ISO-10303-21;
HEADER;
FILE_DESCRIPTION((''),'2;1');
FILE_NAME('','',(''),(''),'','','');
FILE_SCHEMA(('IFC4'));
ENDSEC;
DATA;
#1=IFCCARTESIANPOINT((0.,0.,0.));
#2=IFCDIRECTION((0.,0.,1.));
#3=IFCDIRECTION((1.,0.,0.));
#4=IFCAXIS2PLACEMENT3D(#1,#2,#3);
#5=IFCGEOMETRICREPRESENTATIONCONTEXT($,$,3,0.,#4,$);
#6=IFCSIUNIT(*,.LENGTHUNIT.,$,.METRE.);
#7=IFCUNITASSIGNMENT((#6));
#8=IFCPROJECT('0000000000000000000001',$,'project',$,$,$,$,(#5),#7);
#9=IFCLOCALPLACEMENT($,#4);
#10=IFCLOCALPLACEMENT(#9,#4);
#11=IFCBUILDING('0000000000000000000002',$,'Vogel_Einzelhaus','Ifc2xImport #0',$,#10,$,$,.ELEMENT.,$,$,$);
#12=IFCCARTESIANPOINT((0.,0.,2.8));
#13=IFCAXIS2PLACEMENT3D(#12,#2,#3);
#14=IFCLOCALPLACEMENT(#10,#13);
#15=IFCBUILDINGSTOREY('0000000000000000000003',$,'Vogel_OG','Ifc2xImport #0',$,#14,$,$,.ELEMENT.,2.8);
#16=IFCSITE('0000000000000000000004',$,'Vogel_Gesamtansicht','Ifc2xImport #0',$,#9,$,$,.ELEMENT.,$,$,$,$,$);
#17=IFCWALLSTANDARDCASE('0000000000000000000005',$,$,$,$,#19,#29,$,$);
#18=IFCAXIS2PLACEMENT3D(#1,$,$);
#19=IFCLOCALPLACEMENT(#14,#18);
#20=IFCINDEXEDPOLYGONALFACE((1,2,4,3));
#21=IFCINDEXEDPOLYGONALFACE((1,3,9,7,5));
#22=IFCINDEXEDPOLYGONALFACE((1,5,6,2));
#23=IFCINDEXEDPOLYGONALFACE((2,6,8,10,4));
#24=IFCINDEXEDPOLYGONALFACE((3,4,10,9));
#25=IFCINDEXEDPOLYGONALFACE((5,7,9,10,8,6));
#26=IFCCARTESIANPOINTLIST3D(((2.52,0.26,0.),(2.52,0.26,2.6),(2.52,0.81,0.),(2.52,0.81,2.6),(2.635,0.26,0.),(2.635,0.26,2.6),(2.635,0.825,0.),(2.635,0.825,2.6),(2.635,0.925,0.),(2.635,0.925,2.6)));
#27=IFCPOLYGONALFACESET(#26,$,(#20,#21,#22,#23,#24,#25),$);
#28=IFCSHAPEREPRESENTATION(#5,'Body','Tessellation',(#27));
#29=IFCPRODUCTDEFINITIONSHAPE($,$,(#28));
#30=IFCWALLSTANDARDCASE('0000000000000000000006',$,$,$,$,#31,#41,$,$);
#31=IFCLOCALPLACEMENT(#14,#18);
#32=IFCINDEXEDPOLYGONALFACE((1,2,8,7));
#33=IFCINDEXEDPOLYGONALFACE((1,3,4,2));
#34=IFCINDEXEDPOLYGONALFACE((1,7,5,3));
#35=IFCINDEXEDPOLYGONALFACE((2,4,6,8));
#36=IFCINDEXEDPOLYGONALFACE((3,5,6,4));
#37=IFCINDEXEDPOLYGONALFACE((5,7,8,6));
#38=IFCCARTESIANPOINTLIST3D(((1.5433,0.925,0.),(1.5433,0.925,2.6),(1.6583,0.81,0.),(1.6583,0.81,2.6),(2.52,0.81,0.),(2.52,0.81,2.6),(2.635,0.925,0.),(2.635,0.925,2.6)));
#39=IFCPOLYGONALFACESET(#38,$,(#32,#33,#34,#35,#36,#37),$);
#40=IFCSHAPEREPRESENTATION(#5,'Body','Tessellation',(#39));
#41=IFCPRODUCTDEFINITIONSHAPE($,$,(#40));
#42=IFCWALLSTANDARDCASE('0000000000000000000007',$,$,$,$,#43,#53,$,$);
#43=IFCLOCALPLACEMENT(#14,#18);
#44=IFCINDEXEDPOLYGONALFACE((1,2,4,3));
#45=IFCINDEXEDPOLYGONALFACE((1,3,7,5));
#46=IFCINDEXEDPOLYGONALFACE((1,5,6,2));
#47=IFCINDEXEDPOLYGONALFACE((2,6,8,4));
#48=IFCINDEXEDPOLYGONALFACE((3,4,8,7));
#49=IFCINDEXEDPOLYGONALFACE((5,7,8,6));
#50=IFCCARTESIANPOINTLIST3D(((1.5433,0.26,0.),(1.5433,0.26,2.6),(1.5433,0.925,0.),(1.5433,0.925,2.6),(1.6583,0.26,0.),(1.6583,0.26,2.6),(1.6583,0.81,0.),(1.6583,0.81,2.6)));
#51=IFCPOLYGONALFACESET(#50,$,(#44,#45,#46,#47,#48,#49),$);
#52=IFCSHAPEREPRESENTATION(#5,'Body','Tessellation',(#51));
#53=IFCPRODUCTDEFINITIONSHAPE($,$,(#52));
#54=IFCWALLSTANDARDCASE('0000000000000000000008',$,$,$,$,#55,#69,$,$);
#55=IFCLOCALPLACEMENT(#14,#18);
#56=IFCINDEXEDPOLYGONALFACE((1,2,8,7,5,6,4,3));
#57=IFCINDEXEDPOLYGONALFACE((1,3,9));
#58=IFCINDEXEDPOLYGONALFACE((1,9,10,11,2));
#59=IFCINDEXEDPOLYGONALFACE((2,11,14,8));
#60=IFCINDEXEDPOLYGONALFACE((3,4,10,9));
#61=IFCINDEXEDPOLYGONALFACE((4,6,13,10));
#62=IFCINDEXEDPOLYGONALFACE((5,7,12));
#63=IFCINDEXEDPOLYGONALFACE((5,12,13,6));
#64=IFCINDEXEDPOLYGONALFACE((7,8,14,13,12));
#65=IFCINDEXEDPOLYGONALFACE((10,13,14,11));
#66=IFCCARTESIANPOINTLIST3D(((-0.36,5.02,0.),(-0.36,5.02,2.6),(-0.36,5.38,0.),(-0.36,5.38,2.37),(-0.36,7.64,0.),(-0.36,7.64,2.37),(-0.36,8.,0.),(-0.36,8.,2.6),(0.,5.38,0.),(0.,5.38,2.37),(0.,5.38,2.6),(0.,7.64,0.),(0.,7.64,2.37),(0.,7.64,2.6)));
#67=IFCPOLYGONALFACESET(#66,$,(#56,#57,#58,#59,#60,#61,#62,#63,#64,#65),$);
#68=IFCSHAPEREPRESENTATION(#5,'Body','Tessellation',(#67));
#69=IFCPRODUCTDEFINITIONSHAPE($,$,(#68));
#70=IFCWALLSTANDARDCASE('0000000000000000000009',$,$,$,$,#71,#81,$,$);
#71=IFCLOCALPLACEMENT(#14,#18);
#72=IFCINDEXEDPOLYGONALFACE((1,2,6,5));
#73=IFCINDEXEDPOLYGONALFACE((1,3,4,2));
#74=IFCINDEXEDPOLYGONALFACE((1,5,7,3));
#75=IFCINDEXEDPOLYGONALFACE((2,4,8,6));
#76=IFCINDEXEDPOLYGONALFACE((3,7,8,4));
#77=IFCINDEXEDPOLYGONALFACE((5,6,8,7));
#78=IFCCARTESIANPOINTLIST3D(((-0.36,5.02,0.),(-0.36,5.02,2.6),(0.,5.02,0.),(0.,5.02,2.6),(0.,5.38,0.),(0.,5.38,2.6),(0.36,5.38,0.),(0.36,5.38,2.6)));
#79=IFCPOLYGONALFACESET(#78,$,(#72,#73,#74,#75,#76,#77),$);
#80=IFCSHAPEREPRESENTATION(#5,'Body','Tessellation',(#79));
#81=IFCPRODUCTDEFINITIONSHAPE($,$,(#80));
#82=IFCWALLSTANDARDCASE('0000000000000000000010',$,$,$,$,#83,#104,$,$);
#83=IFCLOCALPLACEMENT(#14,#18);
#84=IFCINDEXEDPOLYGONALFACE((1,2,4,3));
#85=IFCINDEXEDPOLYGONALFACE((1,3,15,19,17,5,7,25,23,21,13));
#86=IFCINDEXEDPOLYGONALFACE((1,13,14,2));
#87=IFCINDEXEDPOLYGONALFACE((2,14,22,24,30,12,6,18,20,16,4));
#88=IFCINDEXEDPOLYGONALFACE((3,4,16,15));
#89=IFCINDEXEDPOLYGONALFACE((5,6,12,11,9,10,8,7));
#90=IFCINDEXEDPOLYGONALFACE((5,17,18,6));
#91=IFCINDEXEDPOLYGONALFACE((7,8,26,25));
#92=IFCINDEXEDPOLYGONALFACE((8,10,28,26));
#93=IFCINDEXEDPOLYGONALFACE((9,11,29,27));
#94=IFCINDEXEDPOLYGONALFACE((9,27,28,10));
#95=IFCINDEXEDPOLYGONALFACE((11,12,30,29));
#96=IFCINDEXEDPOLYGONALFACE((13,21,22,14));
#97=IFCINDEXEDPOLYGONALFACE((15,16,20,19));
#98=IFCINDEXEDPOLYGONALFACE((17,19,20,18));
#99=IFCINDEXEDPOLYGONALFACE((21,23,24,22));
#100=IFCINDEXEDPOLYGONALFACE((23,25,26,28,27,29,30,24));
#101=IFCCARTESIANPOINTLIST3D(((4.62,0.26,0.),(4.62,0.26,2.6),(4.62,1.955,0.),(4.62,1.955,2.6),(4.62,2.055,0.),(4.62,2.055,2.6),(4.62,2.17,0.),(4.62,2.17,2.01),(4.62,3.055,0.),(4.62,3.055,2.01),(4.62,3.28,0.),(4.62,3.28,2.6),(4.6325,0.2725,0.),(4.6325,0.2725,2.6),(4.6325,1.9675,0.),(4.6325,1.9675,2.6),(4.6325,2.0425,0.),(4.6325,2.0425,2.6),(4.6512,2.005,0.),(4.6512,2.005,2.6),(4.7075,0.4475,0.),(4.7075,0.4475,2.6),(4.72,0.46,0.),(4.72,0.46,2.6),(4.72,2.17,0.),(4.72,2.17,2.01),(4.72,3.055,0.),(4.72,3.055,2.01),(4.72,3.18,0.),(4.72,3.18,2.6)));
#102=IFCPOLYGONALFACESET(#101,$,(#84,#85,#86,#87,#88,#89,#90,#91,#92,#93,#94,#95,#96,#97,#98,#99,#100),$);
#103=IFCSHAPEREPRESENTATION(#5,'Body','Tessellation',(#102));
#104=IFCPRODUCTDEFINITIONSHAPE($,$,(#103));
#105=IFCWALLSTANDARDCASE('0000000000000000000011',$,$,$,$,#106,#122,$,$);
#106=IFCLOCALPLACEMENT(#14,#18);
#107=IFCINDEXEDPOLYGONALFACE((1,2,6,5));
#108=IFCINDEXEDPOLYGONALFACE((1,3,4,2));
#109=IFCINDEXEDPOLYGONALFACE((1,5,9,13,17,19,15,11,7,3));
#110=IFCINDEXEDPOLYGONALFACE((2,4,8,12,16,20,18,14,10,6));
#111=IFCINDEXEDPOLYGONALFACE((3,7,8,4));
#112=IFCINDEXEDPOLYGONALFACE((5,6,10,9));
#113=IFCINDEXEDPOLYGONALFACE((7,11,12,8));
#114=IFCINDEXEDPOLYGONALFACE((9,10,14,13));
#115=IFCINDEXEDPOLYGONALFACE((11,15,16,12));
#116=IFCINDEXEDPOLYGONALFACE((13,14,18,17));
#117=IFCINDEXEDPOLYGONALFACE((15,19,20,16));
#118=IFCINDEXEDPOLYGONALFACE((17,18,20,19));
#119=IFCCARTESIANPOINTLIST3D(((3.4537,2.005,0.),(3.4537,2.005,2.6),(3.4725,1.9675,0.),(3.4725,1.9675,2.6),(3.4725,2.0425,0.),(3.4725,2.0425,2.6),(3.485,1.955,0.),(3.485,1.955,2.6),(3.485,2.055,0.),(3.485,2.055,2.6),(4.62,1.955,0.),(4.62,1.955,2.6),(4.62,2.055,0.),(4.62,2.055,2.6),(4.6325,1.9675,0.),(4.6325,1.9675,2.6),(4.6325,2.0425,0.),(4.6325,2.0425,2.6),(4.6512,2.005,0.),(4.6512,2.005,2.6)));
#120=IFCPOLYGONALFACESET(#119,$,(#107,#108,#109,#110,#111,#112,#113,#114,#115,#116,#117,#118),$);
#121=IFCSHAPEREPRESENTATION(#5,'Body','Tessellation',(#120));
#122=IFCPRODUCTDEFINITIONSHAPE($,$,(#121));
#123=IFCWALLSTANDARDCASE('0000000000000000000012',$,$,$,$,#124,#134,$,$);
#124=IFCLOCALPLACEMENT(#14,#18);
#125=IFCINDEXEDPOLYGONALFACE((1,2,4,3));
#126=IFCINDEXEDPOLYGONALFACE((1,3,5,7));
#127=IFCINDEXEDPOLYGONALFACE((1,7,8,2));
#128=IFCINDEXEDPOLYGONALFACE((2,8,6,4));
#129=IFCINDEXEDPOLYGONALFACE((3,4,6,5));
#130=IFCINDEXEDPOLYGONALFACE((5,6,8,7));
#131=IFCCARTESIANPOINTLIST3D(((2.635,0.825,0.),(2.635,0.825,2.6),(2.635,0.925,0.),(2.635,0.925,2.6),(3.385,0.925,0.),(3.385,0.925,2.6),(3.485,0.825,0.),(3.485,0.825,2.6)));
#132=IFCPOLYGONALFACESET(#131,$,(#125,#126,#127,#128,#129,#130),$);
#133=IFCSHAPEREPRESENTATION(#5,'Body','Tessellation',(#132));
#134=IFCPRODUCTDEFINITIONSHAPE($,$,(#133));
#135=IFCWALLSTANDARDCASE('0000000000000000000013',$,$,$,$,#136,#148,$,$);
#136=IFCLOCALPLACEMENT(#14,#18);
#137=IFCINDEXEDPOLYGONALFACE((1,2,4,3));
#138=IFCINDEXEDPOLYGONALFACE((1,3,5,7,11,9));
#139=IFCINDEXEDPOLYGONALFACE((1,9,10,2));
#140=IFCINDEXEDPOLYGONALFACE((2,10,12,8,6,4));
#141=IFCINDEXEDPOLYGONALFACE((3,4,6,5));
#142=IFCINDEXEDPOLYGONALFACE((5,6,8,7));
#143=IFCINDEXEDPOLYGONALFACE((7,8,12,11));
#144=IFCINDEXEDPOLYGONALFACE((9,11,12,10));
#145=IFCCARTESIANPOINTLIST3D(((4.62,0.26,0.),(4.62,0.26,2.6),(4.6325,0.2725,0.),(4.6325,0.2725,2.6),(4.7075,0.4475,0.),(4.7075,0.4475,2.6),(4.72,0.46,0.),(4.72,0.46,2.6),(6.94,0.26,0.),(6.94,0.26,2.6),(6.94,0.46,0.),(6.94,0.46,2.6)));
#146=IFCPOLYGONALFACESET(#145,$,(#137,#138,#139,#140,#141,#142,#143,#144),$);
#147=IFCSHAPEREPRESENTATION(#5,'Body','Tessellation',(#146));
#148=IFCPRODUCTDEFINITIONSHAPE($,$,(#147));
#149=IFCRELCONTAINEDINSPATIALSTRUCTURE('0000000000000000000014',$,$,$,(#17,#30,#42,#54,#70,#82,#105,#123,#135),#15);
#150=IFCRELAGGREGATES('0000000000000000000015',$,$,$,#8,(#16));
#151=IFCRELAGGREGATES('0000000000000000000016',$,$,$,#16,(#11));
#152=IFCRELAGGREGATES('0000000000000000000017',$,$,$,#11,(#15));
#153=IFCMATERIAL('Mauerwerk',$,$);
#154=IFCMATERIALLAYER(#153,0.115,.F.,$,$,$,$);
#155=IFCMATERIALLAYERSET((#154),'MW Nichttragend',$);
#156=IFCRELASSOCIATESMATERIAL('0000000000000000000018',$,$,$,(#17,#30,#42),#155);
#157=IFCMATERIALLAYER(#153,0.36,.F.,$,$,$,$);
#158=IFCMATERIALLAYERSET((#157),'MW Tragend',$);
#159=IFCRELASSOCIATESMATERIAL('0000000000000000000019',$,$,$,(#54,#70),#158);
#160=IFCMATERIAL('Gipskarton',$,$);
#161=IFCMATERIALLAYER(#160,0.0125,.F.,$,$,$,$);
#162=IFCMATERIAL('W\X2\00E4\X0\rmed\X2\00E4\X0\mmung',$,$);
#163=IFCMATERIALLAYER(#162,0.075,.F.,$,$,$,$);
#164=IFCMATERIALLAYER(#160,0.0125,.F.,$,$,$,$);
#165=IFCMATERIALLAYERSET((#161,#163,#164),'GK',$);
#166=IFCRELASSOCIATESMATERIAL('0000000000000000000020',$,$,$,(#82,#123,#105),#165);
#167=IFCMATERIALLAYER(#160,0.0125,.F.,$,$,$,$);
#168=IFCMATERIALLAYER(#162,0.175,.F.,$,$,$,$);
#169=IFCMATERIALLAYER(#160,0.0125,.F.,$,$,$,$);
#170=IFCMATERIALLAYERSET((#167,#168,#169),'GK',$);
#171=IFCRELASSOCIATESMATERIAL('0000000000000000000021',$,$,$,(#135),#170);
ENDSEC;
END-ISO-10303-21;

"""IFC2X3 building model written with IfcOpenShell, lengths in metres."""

from ifc_helpers import new_model, si_unit, frame, origin_with_axes, origin_2d_with_axis, place, context, project, spatial, polyline, rectangle, outline, extrude, shape, material, layer, layer_set, layer_usage, element, save


model = new_model("IFC2X3")

# Units and contexts
context_of_model = context(None, 3, precision=0.0, world=origin_with_axes())
ifc_project = project(units=[si_unit("LENGTHUNIT", "METRE")], contexts=[context_of_model])

# Site, building, storey
site_placement = place(None, origin_with_axes())
site = spatial("IfcSite", under=ifc_project, at=site_placement, Name="Vogel_Gesamtansicht", Description="Ifc2xImport #0", CompositionType="ELEMENT")
building_placement = place(site_placement, origin_with_axes())
building = spatial("IfcBuilding", under=site, at=building_placement, Name="Vogel_Einzelhaus", Description="Ifc2xImport #0", CompositionType="ELEMENT")
storey_placement = place(building_placement, frame((0.0, 0.0, 2.8), z_axis=(0.0, 0.0, 1.0), x_axis=(1.0, 0.0, 0.0)))
storey = spatial("IfcBuildingStorey", under=building, at=storey_placement, Name="Vogel_OG", Description="Ifc2xImport #0", CompositionType="ELEMENT", Elevation=2.8)

# Shared definitions
ifc_material_1 = material(Name="Mauerwerk")

# Shared definitions
ifc_layer_1 = layer(ifc_material_1, 0.36, ventilated=False)
ifc_layer_set_1 = layer_set([ifc_layer_1], Name="MW Tragend")
ifc_layer_usage_1 = layer_usage(ifc_layer_set_1, "AXIS2", "POSITIVE", -0.36)

# Shared definitions
ifc_material_2 = material(Name="Gipskarton")
ifc_layer_2 = layer(ifc_material_2, 0.0125, ventilated=False)
ifc_material_3 = material(Name="Wärmedämmung")
ifc_layer_3 = layer(ifc_material_3, 0.075, ventilated=False)
ifc_layer_4 = layer(ifc_material_2, 0.0125, ventilated=False)
ifc_layer_set_2 = layer_set([ifc_layer_2, ifc_layer_3, ifc_layer_4], Name="GK")
ifc_layer_usage_2 = layer_usage(ifc_layer_set_2, "AXIS2", "POSITIVE", -0.1)

# Shared definitions
ifc_layer_usage_3 = layer_usage(ifc_layer_set_2, "AXIS2", "POSITIVE", 0.0)

# Walls
ifc_layer_5 = layer(ifc_material_1, 0.115, ventilated=False)
ifc_layer_set_3 = layer_set([ifc_layer_5], Name="MW Nichttragend")
ifc_layer_usage_4 = layer_usage(ifc_layer_set_3, "AXIS2", "POSITIVE", -0.115)
wall_1_placement = place(storey_placement, frame((2.52, 0.26, 0.0), z_axis=(0.0, 0.0, 1.0), x_axis=(0.0, 1.0, 0.0)))
element("IfcWallStandardCase", 1, at=wall_1_placement, inside=storey, material=ifc_layer_usage_4, context=context_of_model, shape_type="SweptSolid", body=[
    extrude(outline(polyline([(0.665, -0.115), (0.55, 0.0), (0.0, 0.0), (0.0, -0.115), (0.565, -0.115), (0.665, -0.115)])), origin_with_axes(), (0.0, 0.0, 1.0), 2.6),
])
ifc_layer_usage_5 = layer_usage(ifc_layer_set_3, "AXIS2", "POSITIVE", 0.0)
wall_2_placement = place(storey_placement, frame((1.6583, 0.81, 0.0), z_axis=(0.0, 0.0, 1.0), x_axis=(1.0, 0.0, 0.0)))
element("IfcWallStandardCase", 2, at=wall_2_placement, inside=storey, material=ifc_layer_usage_5, context=context_of_model, shape_type="SweptSolid", body=[
    extrude(outline(polyline([(-0.115, 0.115), (0.0, 0.0), (0.8617, 0.0), (0.9767, 0.115), (-0.115, 0.115)])), origin_with_axes(), (0.0, 0.0, 1.0), 2.6),
])
wall_3_placement = place(storey_placement, frame((1.6583, 0.26, 0.0), z_axis=(0.0, 0.0, 1.0), x_axis=(0.0, 1.0, 0.0)))
element("IfcWallStandardCase", 3, at=wall_3_placement, inside=storey, material=ifc_layer_usage_5, context=context_of_model, shape_type="SweptSolid", body=[
    extrude(outline(polyline([(0.55, 0.0), (0.665, 0.115), (0.0, 0.115), (0.0, 0.0), (0.55, 0.0)])), origin_with_axes(), (0.0, 0.0, 1.0), 2.6),
])

# Wall, opening
wall_4_placement = place(storey_placement, frame((-0.36, 5.02, 0.0), z_axis=(0.0, 0.0, 1.0), x_axis=(0.0, 1.0, 0.0)))
wall_4 = element("IfcWallStandardCase", 4, at=wall_4_placement, inside=storey, material=ifc_layer_usage_1, context=context_of_model, shape_type="SweptSolid", body=[
    extrude(outline(polyline([(0.0, 0.0), (0.36, -0.36), (2.62, -0.36), (2.98, 0.0), (0.0, 0.0)])), origin_with_axes(), (0.0, 0.0, 1.0), 2.6),
])
opening_1_placement = place(wall_4_placement, frame((2.62, -0.36, 0.0), z_axis=(-1.0, 0.0, 0.0), x_axis=(0.0, 0.0, 1.0)))
element("IfcOpeningElement", 5, at=opening_1_placement, cuts=wall_4, shapes=[
    shape(context_of_model, None, "SweptSolid", [extrude(rectangle(XDim=2.37, YDim=2.26, at=origin_2d_with_axis()), frame((1.185, 0.0, 1.13), z_axis=(0.0, 1.0, 0.0), x_axis=(1.0, 0.0, 0.0)), (0.0, 0.0, 1.0), 0.36)]),
])

# Wall
ifc_layer_usage_6 = layer_usage(ifc_layer_set_1, "AXIS2", "POSITIVE", 0.0)
wall_5_placement = place(storey_placement, frame((-0.36, 5.02, 0.0), z_axis=(0.0, 0.0, 1.0), x_axis=(1.0, 0.0, 0.0)))
element("IfcWallStandardCase", 6, at=wall_5_placement, inside=storey, material=ifc_layer_usage_6, context=context_of_model, shape_type="SweptSolid", body=[
    extrude(outline(polyline([(0.36, 0.36), (0.0, 0.0), (0.36, 0.0), (0.72, 0.36), (0.36, 0.36)])), origin_with_axes(), (0.0, 0.0, 1.0), 2.6),
])

# Wall, opening
wall_6_placement = place(storey_placement, frame((4.62, 0.26, 0.0), z_axis=(0.0, 0.0, 1.0), x_axis=(0.0, 1.0, 0.0)))
wall_6 = element("IfcWallStandardCase", 7, at=wall_6_placement, inside=storey, material=ifc_layer_usage_2, context=context_of_model, shape_type="SweptSolid", body=[
    extrude(outline(polyline([(0.1875, -0.0875), (0.2, -0.1), (2.92, -0.1), (3.02, 0.0), (1.795, 0.0), (1.7825, -0.0125), (1.745, -0.0312), (1.7075, -0.0125), (1.695, 0.0), (0.0, 0.0), (0.0125, -0.0125), (0.1875, -0.0875)])), origin_with_axes(), (0.0, 0.0, 1.0), 2.6),
])
opening_2_placement = place(wall_6_placement, frame((2.795, -0.1, 0.0), z_axis=(-1.0, 0.0, 0.0), x_axis=(0.0, 0.0, 1.0)))
element("IfcOpeningElement", 8, at=opening_2_placement, cuts=wall_6, shapes=[
    shape(context_of_model, None, "SweptSolid", [extrude(rectangle(XDim=2.01, YDim=0.885, at=origin_2d_with_axis()), frame((1.005, 0.0, 0.4425), z_axis=(0.0, 1.0, 0.0), x_axis=(1.0, 0.0, 0.0)), (0.0, 0.0, 1.0), 0.1)]),
])

# Walls
wall_7_placement = place(storey_placement, frame((3.485, 1.955, 0.0), z_axis=(0.0, 0.0, 1.0), x_axis=(1.0, 0.0, 0.0)))
element("IfcWallStandardCase", 9, at=wall_7_placement, inside=storey, material=ifc_layer_usage_3, context=context_of_model, shape_type="SweptSolid", body=[
    extrude(outline(polyline([(-0.0125, 0.0125), (0.0, 0.0), (1.135, 0.0), (1.1475, 0.0125), (1.1662, 0.05), (1.1475, 0.0875), (1.135, 0.1), (0.0, 0.1), (-0.0125, 0.0875), (-0.0313, 0.05), (-0.0125, 0.0125)])), origin_with_axes(), (0.0, 0.0, 1.0), 2.6),
])
wall_8_placement = place(storey_placement, frame((2.635, 0.925, 0.0), z_axis=(0.0, 0.0, 1.0), x_axis=(1.0, 0.0, 0.0)))
element("IfcWallStandardCase", 10, at=wall_8_placement, inside=storey, material=ifc_layer_usage_2, context=context_of_model, shape_type="SweptSolid", body=[
    extrude(outline(polyline([(0.85, -0.1), (0.75, 0.0), (0.0, 0.0), (0.0, -0.1), (0.85, -0.1)])), origin_with_axes(), (0.0, 0.0, 1.0), 2.6),
])
ifc_layer_6 = layer(ifc_material_2, 0.0125, ventilated=False)
ifc_layer_7 = layer(ifc_material_3, 0.175, ventilated=False)
ifc_layer_8 = layer(ifc_material_2, 0.0125, ventilated=False)
ifc_layer_set_4 = layer_set([ifc_layer_6, ifc_layer_7, ifc_layer_8], Name="GK")
ifc_layer_usage_7 = layer_usage(ifc_layer_set_4, "AXIS2", "POSITIVE", 0.0)
wall_9_placement = place(storey_placement, frame((4.72, 0.26, 0.0), z_axis=(0.0, 0.0, 1.0), x_axis=(1.0, 0.0, 0.0)))
element("IfcWallStandardCase", 11, at=wall_9_placement, inside=storey, material=ifc_layer_usage_7, context=context_of_model, shape_type="SweptSolid", body=[
    extrude(outline(polyline([(-0.0875, 0.0125), (-0.1, 0.0), (2.22, 0.0), (2.22, 0.2), (0.0, 0.2), (-0.0125, 0.1875), (-0.0875, 0.0125)])), origin_with_axes(), (0.0, 0.0, 1.0), 2.6),
])

save(model, "model.ifc")
